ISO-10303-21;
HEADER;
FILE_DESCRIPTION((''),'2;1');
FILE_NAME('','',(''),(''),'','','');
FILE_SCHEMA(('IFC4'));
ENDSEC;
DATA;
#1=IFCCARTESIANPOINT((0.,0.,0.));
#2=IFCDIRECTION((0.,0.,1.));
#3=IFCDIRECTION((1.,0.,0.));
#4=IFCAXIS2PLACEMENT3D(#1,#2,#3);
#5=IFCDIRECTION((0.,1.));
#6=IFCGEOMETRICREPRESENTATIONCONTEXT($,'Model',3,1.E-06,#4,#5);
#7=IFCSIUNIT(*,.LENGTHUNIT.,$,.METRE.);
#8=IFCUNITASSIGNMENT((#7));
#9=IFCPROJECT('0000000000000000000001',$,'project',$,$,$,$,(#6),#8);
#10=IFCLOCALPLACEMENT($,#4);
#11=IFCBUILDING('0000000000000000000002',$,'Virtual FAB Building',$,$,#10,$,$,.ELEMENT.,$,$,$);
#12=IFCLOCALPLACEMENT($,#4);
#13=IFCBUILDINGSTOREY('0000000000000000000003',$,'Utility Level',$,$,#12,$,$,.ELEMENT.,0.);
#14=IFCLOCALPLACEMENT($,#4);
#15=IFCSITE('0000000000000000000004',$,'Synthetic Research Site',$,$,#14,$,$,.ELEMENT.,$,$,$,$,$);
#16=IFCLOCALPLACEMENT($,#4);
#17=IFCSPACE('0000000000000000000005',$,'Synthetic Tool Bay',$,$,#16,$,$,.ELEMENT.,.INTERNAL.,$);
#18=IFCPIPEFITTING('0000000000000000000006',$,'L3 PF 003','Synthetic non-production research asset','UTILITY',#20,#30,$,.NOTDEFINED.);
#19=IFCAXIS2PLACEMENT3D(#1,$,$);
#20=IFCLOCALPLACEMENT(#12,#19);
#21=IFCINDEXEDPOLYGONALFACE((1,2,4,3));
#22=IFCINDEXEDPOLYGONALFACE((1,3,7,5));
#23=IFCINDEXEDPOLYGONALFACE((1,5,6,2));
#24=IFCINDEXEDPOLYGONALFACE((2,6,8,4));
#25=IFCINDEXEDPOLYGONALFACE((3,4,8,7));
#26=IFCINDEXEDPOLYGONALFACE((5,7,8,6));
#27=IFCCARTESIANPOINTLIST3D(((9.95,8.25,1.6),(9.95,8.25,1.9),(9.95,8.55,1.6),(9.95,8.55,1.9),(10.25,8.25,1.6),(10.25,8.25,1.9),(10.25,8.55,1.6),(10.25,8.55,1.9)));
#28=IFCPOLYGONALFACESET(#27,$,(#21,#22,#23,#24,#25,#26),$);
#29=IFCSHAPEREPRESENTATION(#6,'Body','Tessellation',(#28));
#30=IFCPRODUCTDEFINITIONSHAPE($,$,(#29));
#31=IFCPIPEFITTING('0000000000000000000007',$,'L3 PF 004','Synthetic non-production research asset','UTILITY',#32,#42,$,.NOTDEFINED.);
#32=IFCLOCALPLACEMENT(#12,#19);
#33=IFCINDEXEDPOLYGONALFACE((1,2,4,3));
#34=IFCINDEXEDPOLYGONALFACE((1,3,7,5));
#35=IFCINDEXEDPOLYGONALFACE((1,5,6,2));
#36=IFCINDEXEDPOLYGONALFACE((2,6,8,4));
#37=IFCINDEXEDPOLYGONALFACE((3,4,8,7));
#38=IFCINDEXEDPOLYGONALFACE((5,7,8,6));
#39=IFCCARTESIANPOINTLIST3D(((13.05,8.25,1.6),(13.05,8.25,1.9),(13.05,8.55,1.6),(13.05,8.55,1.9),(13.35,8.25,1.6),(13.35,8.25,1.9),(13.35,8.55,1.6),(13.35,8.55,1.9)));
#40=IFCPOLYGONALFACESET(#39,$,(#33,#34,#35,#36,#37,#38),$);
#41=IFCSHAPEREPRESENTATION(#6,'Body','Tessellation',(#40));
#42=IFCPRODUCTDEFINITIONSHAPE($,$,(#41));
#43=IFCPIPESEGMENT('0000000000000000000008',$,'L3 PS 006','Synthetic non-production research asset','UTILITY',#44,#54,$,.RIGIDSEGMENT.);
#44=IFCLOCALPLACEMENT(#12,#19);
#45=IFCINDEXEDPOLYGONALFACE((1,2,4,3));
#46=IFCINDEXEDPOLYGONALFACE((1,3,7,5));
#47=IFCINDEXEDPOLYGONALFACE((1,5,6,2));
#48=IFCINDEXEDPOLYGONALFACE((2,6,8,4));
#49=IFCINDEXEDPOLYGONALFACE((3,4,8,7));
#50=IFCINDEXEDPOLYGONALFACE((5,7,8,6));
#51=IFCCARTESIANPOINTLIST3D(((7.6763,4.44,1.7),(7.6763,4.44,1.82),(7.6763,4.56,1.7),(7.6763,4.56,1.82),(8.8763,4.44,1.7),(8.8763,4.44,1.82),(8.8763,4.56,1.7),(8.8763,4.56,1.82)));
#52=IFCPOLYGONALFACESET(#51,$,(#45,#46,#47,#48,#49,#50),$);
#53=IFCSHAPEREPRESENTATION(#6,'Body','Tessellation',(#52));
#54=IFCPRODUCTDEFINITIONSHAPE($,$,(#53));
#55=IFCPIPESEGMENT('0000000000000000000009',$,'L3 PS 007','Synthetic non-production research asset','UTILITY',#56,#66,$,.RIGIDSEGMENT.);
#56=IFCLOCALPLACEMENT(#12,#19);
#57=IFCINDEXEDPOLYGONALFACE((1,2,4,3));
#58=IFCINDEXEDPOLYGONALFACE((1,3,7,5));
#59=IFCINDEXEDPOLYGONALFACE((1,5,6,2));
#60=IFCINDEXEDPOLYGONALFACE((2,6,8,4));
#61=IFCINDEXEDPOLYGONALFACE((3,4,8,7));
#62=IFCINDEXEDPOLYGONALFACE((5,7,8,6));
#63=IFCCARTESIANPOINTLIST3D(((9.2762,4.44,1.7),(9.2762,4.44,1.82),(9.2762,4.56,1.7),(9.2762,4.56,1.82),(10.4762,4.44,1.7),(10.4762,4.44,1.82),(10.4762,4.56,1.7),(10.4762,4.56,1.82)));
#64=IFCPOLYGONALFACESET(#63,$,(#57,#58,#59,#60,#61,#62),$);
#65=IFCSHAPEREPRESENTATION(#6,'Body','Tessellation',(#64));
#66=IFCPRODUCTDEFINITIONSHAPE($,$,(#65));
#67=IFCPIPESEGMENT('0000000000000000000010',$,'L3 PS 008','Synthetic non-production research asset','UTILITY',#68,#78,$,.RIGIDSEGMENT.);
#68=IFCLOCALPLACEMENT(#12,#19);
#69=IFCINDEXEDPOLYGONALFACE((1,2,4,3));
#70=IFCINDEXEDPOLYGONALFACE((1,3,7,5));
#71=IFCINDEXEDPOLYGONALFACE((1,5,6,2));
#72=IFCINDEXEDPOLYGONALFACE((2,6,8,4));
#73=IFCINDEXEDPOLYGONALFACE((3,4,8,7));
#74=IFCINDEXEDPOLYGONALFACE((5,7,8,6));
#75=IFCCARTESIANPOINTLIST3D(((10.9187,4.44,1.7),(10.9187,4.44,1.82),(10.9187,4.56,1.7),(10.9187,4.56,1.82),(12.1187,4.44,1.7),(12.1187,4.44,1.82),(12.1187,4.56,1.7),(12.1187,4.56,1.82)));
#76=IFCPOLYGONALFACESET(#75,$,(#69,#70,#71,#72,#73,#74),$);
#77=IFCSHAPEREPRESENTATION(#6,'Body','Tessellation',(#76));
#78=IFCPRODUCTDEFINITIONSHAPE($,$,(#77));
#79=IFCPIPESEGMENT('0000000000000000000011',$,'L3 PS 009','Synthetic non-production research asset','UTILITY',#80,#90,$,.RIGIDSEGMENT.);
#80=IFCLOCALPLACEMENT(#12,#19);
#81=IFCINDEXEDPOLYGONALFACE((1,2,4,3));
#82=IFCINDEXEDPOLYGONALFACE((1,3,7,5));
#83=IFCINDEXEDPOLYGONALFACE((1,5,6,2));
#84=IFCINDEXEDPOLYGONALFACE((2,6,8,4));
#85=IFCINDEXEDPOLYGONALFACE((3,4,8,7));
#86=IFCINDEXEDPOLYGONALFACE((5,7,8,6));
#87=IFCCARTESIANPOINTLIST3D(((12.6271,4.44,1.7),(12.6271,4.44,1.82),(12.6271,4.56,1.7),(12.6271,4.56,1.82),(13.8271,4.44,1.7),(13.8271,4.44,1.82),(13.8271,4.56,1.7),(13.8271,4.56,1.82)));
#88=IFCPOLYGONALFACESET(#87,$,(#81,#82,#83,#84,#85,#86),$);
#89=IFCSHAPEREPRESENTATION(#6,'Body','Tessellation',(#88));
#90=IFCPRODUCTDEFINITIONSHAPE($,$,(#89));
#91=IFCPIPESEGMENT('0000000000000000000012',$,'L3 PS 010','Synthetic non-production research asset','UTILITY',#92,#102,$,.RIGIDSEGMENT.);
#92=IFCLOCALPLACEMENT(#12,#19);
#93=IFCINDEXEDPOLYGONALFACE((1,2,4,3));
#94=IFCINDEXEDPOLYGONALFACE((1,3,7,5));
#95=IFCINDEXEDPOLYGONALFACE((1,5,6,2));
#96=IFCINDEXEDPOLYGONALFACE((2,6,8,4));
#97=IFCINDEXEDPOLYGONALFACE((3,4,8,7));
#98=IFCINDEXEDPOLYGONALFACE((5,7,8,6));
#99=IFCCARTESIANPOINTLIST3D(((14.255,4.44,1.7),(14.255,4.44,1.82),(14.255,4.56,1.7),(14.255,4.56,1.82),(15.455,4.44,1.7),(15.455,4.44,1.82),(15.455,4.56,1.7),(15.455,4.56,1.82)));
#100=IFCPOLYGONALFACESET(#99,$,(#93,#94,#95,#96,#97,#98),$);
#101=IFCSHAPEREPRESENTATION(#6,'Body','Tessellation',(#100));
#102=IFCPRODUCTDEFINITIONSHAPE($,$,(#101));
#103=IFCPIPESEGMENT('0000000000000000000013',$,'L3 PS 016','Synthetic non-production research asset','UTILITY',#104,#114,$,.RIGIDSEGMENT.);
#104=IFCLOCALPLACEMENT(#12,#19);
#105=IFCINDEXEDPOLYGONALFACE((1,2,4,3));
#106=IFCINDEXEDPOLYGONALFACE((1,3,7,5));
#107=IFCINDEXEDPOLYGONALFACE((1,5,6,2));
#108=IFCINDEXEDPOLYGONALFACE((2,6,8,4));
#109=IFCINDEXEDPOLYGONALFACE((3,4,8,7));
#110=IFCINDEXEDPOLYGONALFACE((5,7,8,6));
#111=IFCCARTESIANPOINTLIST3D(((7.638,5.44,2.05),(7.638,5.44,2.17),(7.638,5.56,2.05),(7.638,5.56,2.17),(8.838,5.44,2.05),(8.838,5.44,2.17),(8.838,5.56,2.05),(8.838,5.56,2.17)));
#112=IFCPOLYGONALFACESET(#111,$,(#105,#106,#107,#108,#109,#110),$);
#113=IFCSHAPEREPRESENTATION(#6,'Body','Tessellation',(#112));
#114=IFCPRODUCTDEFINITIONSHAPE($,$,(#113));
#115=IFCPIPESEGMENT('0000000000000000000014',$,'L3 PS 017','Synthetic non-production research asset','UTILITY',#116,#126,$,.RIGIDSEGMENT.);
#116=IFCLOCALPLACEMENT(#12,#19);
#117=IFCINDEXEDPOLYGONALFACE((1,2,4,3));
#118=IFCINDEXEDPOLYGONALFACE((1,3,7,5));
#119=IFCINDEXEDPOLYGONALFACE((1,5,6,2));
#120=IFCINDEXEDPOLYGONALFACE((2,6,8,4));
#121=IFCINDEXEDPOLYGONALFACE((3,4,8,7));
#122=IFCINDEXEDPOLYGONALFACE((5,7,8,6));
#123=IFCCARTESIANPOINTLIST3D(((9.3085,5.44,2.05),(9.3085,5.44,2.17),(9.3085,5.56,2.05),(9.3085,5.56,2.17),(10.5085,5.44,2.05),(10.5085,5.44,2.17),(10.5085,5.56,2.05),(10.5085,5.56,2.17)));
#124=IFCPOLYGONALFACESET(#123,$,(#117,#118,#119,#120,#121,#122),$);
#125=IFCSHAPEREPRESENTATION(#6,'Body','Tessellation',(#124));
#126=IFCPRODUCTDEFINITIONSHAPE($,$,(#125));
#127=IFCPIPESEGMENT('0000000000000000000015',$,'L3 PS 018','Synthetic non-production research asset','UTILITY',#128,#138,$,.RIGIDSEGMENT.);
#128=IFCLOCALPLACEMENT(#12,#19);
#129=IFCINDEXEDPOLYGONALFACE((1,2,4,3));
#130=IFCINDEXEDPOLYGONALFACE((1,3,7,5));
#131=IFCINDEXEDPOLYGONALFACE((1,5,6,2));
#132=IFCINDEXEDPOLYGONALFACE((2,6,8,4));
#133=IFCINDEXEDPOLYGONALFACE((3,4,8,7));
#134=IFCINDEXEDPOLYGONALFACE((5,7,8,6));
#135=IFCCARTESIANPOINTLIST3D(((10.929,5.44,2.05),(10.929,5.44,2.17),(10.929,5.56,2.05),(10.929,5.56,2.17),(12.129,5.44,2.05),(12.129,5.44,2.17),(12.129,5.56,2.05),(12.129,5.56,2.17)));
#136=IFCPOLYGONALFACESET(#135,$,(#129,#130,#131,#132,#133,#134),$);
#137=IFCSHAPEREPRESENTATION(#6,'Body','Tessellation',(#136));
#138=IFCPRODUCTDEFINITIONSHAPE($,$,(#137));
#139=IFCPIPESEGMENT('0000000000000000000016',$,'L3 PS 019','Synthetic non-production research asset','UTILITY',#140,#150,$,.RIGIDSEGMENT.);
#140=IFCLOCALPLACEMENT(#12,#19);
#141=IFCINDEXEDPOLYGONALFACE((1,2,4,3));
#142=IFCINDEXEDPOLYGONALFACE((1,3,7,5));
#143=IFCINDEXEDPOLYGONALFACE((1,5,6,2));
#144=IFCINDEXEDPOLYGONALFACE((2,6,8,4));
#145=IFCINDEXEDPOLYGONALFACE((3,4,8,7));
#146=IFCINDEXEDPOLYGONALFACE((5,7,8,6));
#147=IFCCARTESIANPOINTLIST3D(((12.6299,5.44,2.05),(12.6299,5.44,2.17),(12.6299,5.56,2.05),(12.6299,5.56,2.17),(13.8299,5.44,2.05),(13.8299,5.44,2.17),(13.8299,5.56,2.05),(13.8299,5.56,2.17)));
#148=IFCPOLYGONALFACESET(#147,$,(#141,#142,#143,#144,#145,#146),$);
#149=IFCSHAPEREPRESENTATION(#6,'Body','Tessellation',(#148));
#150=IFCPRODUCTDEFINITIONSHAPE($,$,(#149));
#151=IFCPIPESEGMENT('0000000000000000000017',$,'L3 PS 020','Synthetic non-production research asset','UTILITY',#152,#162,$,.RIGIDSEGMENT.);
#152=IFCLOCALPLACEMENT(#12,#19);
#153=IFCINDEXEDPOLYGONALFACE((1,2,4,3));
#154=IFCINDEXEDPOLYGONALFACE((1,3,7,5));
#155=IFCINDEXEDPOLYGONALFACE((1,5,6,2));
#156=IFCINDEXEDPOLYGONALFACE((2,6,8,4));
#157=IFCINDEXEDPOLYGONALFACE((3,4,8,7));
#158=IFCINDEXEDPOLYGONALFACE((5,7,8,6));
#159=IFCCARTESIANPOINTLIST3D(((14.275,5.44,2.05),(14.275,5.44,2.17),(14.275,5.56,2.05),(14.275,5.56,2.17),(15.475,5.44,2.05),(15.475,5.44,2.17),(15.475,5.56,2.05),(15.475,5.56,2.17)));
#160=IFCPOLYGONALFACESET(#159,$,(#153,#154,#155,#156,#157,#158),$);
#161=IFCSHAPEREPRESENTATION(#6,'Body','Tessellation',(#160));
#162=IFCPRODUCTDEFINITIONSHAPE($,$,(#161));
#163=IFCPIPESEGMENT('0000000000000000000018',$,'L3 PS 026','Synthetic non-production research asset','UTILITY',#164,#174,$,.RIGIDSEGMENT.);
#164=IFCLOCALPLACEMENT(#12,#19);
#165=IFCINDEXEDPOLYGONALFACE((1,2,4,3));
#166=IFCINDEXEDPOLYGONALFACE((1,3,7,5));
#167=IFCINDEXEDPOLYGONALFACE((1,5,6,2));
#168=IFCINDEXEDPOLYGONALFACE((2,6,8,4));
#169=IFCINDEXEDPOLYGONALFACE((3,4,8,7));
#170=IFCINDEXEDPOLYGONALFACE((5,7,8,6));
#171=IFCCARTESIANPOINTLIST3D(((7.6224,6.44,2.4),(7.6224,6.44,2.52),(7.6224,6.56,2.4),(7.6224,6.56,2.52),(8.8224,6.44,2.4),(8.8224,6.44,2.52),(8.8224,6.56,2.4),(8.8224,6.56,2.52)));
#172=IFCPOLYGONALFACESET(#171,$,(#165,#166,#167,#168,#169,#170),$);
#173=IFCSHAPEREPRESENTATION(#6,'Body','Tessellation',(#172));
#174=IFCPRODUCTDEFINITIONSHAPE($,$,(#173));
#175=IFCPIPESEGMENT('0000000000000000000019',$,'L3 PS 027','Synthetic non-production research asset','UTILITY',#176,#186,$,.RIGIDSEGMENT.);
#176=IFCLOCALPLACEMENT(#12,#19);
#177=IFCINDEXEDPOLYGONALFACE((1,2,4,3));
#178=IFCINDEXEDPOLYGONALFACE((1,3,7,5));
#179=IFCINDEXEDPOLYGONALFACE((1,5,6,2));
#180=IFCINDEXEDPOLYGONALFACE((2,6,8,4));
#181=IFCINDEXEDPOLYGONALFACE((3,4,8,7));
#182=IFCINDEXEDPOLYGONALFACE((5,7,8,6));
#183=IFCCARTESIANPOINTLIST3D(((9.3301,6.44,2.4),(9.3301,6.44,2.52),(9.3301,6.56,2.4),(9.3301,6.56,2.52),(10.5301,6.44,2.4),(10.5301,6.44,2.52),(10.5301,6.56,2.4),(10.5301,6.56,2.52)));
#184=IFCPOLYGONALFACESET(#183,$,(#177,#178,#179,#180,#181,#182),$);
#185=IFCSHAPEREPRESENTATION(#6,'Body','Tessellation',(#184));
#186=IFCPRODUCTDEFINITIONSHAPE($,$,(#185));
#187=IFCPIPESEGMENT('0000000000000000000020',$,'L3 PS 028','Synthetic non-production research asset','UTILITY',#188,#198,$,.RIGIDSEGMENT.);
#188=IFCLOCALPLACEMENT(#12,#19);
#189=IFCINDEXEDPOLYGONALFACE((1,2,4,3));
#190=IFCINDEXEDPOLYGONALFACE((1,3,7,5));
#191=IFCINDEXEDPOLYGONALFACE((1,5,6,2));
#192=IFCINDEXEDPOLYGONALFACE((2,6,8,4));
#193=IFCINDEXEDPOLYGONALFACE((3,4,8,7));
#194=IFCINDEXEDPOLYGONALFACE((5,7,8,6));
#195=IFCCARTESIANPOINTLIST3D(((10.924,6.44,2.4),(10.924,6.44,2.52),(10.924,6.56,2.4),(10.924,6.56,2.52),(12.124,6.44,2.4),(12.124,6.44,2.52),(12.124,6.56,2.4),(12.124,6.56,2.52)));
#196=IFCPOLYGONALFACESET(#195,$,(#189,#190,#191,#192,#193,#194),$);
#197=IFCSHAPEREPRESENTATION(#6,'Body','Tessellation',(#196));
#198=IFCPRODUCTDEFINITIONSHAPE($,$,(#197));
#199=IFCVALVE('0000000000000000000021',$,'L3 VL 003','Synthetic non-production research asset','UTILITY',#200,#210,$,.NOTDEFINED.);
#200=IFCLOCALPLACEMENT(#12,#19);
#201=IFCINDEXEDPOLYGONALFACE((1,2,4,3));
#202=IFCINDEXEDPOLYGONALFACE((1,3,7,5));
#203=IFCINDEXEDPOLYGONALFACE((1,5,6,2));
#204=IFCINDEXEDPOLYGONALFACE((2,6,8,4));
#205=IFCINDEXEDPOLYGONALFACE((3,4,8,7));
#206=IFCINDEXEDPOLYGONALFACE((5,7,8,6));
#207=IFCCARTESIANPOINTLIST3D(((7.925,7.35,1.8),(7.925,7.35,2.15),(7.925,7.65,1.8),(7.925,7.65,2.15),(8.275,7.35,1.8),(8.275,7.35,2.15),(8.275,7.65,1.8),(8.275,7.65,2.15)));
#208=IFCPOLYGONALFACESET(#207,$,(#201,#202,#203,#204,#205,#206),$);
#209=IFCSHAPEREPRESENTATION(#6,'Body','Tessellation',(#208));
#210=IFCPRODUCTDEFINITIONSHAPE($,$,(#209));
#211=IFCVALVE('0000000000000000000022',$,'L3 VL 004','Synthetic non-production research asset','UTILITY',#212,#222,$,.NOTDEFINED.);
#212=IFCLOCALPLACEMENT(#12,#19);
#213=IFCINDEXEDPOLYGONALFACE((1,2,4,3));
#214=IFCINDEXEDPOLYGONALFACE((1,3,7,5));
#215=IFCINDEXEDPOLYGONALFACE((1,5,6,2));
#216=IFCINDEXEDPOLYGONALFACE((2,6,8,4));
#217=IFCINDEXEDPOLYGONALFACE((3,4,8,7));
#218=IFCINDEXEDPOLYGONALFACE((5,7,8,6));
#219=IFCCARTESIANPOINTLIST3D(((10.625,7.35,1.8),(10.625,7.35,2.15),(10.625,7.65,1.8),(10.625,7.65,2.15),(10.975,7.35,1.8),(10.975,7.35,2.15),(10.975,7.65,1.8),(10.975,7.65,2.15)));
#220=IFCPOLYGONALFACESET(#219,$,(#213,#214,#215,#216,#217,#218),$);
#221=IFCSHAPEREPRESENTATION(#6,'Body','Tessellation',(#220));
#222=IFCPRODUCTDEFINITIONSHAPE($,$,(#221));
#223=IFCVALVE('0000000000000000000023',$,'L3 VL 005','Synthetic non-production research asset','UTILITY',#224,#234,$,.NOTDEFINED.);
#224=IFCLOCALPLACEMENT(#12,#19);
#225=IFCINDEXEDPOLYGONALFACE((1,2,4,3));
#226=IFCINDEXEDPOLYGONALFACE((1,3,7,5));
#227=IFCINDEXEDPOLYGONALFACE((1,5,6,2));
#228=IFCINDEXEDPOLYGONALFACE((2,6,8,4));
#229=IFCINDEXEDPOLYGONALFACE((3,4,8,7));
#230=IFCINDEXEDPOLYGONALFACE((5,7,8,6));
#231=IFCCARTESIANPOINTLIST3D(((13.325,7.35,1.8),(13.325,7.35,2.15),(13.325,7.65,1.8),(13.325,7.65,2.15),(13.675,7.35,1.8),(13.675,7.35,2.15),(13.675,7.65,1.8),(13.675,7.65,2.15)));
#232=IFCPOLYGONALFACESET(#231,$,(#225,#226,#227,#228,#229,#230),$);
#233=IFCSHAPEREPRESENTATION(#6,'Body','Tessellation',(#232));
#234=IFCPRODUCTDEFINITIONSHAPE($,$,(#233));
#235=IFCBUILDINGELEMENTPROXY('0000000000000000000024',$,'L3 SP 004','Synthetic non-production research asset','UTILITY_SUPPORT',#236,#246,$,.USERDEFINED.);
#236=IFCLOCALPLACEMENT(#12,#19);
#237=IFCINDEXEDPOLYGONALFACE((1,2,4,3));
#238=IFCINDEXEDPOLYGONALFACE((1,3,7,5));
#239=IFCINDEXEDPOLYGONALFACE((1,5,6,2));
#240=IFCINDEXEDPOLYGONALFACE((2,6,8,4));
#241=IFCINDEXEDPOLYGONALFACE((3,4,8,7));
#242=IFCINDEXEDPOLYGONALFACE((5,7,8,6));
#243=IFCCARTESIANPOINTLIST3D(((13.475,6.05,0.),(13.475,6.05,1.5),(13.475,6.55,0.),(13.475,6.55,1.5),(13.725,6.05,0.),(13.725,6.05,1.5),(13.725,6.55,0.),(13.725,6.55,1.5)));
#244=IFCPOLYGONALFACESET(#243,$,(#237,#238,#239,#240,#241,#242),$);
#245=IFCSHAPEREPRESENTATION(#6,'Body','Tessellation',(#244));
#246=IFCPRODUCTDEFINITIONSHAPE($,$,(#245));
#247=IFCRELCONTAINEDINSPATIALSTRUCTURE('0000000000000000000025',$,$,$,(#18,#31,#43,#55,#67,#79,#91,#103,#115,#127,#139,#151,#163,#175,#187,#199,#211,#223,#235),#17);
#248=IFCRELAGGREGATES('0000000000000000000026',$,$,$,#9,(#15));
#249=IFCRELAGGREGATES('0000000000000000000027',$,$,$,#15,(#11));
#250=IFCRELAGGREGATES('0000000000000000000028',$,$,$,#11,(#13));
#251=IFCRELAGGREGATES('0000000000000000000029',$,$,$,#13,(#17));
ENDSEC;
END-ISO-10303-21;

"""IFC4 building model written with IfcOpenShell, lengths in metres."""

from ifc_helpers import new_model, si_unit, direction, frame, origin_with_axes, origin_2d_with_axis, place, context, project, spatial, rectangle, extrude, element, save


model = new_model("IFC4")

# Units and contexts
model_context = context("Model", 3, precision=1e-06, world=origin_with_axes(), true_north=direction((0.0, 1.0)))
ifc_project = project(units=[si_unit("LENGTHUNIT", "METRE")], contexts=[model_context])

# Site, building, storey, space
site_placement = place(None, origin_with_axes())
site = spatial("IfcSite", under=ifc_project, at=site_placement, Name="Synthetic Research Site", CompositionType="ELEMENT")
building_placement = place(None, origin_with_axes())
building = spatial("IfcBuilding", under=site, at=building_placement, Name="Virtual FAB Building", CompositionType="ELEMENT")
storey_placement = place(None, origin_with_axes())
storey = spatial("IfcBuildingStorey", under=building, at=storey_placement, Name="Utility Level", CompositionType="ELEMENT", Elevation=0.0)
space_placement = place(None, origin_with_axes())
space = spatial("IfcSpace", under=storey, at=space_placement, Name="Synthetic Tool Bay", CompositionType="ELEMENT", PredefinedType="INTERNAL")

# Pipe fittings
for number, where, z_axis, x_axis, name in (
    (1, (10.1, 8.4, 1.6), (0.0, 0.0, 1.0), (1.0, 0.0, 0.0), "L3 PF 003"),
    (2, (13.2, 8.4, 1.6), (0.0, 0.0, 1.0), (1.0, 0.0, 0.0), "L3 PF 004"),
):
    element("IfcPipeFitting", number, at=place(None, frame(where, z_axis=z_axis, x_axis=x_axis)), inside=space, Name=name, Description="Synthetic non-production research asset", ObjectType="UTILITY", PredefinedType="NOTDEFINED", context=model_context, shape_type="SweptSolid", body=[
        extrude(rectangle(XDim=0.3, YDim=0.3, at=origin_2d_with_axis()), origin_with_axes(), (0.0, 0.0, 1.0), 0.3),
    ])

# Pipe segments
for number, where, z_axis, x_axis, name in (
    (3, (8.2763, 4.5, 1.7), (0.0, 0.0, 1.0), (1.0, 0.0, 0.0), "L3 PS 006"),
    (4, (9.8762, 4.5, 1.7), (0.0, 0.0, 1.0), (1.0, 0.0, 0.0), "L3 PS 007"),
    (5, (11.5187, 4.5, 1.7), (0.0, 0.0, 1.0), (1.0, 0.0, 0.0), "L3 PS 008"),
    (6, (13.2271, 4.5, 1.7), (0.0, 0.0, 1.0), (1.0, 0.0, 0.0), "L3 PS 009"),
    (7, (14.855, 4.5, 1.7), (0.0, 0.0, 1.0), (1.0, 0.0, 0.0), "L3 PS 010"),
    (8, (8.238, 5.5, 2.05), (0.0, 0.0, 1.0), (1.0, 0.0, 0.0), "L3 PS 016"),
    (9, (9.9085, 5.5, 2.05), (0.0, 0.0, 1.0), (1.0, 0.0, 0.0), "L3 PS 017"),
    (10, (11.529, 5.5, 2.05), (0.0, 0.0, 1.0), (1.0, 0.0, 0.0), "L3 PS 018"),
    (11, (13.2299, 5.5, 2.05), (0.0, 0.0, 1.0), (1.0, 0.0, 0.0), "L3 PS 019"),
    (12, (14.875, 5.5, 2.05), (0.0, 0.0, 1.0), (1.0, 0.0, 0.0), "L3 PS 020"),
    (13, (8.2224, 6.5, 2.4), (0.0, 0.0, 1.0), (1.0, 0.0, 0.0), "L3 PS 026"),
    (14, (9.9301, 6.5, 2.4), (0.0, 0.0, 1.0), (1.0, 0.0, 0.0), "L3 PS 027"),
    (15, (11.524, 6.5, 2.4), (0.0, 0.0, 1.0), (1.0, 0.0, 0.0), "L3 PS 028"),
):
    element("IfcPipeSegment", number, at=place(None, frame(where, z_axis=z_axis, x_axis=x_axis)), inside=space, Name=name, Description="Synthetic non-production research asset", ObjectType="UTILITY", PredefinedType="RIGIDSEGMENT", context=model_context, shape_type="SweptSolid", body=[
        extrude(rectangle(XDim=1.2, YDim=0.12, at=origin_2d_with_axis()), origin_with_axes(), (0.0, 0.0, 1.0), 0.12),
    ])

# Valves
for number, where, z_axis, x_axis, name in (
    (16, (8.1, 7.5, 1.8), (0.0, 0.0, 1.0), (1.0, 0.0, 0.0), "L3 VL 003"),
    (17, (10.8, 7.5, 1.8), (0.0, 0.0, 1.0), (1.0, 0.0, 0.0), "L3 VL 004"),
    (18, (13.5, 7.5, 1.8), (0.0, 0.0, 1.0), (1.0, 0.0, 0.0), "L3 VL 005"),
):
    element("IfcValve", number, at=place(None, frame(where, z_axis=z_axis, x_axis=x_axis)), inside=space, Name=name, Description="Synthetic non-production research asset", ObjectType="UTILITY", PredefinedType="NOTDEFINED", context=model_context, shape_type="SweptSolid", body=[
        extrude(rectangle(XDim=0.35, YDim=0.3, at=origin_2d_with_axis()), origin_with_axes(), (0.0, 0.0, 1.0), 0.35),
    ])

# Building element proxy
for number, where, z_axis, x_axis, name in (
    (19, (13.6, 6.3, 0.0), (0.0, 0.0, 1.0), (1.0, 0.0, 0.0), "L3 SP 004"),
):
    element("IfcBuildingElementProxy", number, at=place(None, frame(where, z_axis=z_axis, x_axis=x_axis)), inside=space, Name=name, Description="Synthetic non-production research asset", ObjectType="UTILITY_SUPPORT", PredefinedType="USERDEFINED", context=model_context, shape_type="SweptSolid", body=[
        extrude(rectangle(XDim=0.25, YDim=0.5, at=origin_2d_with_axis()), origin_with_axes(), (0.0, 0.0, 1.0), 1.5),
    ])

save(model, "model.ifc")
